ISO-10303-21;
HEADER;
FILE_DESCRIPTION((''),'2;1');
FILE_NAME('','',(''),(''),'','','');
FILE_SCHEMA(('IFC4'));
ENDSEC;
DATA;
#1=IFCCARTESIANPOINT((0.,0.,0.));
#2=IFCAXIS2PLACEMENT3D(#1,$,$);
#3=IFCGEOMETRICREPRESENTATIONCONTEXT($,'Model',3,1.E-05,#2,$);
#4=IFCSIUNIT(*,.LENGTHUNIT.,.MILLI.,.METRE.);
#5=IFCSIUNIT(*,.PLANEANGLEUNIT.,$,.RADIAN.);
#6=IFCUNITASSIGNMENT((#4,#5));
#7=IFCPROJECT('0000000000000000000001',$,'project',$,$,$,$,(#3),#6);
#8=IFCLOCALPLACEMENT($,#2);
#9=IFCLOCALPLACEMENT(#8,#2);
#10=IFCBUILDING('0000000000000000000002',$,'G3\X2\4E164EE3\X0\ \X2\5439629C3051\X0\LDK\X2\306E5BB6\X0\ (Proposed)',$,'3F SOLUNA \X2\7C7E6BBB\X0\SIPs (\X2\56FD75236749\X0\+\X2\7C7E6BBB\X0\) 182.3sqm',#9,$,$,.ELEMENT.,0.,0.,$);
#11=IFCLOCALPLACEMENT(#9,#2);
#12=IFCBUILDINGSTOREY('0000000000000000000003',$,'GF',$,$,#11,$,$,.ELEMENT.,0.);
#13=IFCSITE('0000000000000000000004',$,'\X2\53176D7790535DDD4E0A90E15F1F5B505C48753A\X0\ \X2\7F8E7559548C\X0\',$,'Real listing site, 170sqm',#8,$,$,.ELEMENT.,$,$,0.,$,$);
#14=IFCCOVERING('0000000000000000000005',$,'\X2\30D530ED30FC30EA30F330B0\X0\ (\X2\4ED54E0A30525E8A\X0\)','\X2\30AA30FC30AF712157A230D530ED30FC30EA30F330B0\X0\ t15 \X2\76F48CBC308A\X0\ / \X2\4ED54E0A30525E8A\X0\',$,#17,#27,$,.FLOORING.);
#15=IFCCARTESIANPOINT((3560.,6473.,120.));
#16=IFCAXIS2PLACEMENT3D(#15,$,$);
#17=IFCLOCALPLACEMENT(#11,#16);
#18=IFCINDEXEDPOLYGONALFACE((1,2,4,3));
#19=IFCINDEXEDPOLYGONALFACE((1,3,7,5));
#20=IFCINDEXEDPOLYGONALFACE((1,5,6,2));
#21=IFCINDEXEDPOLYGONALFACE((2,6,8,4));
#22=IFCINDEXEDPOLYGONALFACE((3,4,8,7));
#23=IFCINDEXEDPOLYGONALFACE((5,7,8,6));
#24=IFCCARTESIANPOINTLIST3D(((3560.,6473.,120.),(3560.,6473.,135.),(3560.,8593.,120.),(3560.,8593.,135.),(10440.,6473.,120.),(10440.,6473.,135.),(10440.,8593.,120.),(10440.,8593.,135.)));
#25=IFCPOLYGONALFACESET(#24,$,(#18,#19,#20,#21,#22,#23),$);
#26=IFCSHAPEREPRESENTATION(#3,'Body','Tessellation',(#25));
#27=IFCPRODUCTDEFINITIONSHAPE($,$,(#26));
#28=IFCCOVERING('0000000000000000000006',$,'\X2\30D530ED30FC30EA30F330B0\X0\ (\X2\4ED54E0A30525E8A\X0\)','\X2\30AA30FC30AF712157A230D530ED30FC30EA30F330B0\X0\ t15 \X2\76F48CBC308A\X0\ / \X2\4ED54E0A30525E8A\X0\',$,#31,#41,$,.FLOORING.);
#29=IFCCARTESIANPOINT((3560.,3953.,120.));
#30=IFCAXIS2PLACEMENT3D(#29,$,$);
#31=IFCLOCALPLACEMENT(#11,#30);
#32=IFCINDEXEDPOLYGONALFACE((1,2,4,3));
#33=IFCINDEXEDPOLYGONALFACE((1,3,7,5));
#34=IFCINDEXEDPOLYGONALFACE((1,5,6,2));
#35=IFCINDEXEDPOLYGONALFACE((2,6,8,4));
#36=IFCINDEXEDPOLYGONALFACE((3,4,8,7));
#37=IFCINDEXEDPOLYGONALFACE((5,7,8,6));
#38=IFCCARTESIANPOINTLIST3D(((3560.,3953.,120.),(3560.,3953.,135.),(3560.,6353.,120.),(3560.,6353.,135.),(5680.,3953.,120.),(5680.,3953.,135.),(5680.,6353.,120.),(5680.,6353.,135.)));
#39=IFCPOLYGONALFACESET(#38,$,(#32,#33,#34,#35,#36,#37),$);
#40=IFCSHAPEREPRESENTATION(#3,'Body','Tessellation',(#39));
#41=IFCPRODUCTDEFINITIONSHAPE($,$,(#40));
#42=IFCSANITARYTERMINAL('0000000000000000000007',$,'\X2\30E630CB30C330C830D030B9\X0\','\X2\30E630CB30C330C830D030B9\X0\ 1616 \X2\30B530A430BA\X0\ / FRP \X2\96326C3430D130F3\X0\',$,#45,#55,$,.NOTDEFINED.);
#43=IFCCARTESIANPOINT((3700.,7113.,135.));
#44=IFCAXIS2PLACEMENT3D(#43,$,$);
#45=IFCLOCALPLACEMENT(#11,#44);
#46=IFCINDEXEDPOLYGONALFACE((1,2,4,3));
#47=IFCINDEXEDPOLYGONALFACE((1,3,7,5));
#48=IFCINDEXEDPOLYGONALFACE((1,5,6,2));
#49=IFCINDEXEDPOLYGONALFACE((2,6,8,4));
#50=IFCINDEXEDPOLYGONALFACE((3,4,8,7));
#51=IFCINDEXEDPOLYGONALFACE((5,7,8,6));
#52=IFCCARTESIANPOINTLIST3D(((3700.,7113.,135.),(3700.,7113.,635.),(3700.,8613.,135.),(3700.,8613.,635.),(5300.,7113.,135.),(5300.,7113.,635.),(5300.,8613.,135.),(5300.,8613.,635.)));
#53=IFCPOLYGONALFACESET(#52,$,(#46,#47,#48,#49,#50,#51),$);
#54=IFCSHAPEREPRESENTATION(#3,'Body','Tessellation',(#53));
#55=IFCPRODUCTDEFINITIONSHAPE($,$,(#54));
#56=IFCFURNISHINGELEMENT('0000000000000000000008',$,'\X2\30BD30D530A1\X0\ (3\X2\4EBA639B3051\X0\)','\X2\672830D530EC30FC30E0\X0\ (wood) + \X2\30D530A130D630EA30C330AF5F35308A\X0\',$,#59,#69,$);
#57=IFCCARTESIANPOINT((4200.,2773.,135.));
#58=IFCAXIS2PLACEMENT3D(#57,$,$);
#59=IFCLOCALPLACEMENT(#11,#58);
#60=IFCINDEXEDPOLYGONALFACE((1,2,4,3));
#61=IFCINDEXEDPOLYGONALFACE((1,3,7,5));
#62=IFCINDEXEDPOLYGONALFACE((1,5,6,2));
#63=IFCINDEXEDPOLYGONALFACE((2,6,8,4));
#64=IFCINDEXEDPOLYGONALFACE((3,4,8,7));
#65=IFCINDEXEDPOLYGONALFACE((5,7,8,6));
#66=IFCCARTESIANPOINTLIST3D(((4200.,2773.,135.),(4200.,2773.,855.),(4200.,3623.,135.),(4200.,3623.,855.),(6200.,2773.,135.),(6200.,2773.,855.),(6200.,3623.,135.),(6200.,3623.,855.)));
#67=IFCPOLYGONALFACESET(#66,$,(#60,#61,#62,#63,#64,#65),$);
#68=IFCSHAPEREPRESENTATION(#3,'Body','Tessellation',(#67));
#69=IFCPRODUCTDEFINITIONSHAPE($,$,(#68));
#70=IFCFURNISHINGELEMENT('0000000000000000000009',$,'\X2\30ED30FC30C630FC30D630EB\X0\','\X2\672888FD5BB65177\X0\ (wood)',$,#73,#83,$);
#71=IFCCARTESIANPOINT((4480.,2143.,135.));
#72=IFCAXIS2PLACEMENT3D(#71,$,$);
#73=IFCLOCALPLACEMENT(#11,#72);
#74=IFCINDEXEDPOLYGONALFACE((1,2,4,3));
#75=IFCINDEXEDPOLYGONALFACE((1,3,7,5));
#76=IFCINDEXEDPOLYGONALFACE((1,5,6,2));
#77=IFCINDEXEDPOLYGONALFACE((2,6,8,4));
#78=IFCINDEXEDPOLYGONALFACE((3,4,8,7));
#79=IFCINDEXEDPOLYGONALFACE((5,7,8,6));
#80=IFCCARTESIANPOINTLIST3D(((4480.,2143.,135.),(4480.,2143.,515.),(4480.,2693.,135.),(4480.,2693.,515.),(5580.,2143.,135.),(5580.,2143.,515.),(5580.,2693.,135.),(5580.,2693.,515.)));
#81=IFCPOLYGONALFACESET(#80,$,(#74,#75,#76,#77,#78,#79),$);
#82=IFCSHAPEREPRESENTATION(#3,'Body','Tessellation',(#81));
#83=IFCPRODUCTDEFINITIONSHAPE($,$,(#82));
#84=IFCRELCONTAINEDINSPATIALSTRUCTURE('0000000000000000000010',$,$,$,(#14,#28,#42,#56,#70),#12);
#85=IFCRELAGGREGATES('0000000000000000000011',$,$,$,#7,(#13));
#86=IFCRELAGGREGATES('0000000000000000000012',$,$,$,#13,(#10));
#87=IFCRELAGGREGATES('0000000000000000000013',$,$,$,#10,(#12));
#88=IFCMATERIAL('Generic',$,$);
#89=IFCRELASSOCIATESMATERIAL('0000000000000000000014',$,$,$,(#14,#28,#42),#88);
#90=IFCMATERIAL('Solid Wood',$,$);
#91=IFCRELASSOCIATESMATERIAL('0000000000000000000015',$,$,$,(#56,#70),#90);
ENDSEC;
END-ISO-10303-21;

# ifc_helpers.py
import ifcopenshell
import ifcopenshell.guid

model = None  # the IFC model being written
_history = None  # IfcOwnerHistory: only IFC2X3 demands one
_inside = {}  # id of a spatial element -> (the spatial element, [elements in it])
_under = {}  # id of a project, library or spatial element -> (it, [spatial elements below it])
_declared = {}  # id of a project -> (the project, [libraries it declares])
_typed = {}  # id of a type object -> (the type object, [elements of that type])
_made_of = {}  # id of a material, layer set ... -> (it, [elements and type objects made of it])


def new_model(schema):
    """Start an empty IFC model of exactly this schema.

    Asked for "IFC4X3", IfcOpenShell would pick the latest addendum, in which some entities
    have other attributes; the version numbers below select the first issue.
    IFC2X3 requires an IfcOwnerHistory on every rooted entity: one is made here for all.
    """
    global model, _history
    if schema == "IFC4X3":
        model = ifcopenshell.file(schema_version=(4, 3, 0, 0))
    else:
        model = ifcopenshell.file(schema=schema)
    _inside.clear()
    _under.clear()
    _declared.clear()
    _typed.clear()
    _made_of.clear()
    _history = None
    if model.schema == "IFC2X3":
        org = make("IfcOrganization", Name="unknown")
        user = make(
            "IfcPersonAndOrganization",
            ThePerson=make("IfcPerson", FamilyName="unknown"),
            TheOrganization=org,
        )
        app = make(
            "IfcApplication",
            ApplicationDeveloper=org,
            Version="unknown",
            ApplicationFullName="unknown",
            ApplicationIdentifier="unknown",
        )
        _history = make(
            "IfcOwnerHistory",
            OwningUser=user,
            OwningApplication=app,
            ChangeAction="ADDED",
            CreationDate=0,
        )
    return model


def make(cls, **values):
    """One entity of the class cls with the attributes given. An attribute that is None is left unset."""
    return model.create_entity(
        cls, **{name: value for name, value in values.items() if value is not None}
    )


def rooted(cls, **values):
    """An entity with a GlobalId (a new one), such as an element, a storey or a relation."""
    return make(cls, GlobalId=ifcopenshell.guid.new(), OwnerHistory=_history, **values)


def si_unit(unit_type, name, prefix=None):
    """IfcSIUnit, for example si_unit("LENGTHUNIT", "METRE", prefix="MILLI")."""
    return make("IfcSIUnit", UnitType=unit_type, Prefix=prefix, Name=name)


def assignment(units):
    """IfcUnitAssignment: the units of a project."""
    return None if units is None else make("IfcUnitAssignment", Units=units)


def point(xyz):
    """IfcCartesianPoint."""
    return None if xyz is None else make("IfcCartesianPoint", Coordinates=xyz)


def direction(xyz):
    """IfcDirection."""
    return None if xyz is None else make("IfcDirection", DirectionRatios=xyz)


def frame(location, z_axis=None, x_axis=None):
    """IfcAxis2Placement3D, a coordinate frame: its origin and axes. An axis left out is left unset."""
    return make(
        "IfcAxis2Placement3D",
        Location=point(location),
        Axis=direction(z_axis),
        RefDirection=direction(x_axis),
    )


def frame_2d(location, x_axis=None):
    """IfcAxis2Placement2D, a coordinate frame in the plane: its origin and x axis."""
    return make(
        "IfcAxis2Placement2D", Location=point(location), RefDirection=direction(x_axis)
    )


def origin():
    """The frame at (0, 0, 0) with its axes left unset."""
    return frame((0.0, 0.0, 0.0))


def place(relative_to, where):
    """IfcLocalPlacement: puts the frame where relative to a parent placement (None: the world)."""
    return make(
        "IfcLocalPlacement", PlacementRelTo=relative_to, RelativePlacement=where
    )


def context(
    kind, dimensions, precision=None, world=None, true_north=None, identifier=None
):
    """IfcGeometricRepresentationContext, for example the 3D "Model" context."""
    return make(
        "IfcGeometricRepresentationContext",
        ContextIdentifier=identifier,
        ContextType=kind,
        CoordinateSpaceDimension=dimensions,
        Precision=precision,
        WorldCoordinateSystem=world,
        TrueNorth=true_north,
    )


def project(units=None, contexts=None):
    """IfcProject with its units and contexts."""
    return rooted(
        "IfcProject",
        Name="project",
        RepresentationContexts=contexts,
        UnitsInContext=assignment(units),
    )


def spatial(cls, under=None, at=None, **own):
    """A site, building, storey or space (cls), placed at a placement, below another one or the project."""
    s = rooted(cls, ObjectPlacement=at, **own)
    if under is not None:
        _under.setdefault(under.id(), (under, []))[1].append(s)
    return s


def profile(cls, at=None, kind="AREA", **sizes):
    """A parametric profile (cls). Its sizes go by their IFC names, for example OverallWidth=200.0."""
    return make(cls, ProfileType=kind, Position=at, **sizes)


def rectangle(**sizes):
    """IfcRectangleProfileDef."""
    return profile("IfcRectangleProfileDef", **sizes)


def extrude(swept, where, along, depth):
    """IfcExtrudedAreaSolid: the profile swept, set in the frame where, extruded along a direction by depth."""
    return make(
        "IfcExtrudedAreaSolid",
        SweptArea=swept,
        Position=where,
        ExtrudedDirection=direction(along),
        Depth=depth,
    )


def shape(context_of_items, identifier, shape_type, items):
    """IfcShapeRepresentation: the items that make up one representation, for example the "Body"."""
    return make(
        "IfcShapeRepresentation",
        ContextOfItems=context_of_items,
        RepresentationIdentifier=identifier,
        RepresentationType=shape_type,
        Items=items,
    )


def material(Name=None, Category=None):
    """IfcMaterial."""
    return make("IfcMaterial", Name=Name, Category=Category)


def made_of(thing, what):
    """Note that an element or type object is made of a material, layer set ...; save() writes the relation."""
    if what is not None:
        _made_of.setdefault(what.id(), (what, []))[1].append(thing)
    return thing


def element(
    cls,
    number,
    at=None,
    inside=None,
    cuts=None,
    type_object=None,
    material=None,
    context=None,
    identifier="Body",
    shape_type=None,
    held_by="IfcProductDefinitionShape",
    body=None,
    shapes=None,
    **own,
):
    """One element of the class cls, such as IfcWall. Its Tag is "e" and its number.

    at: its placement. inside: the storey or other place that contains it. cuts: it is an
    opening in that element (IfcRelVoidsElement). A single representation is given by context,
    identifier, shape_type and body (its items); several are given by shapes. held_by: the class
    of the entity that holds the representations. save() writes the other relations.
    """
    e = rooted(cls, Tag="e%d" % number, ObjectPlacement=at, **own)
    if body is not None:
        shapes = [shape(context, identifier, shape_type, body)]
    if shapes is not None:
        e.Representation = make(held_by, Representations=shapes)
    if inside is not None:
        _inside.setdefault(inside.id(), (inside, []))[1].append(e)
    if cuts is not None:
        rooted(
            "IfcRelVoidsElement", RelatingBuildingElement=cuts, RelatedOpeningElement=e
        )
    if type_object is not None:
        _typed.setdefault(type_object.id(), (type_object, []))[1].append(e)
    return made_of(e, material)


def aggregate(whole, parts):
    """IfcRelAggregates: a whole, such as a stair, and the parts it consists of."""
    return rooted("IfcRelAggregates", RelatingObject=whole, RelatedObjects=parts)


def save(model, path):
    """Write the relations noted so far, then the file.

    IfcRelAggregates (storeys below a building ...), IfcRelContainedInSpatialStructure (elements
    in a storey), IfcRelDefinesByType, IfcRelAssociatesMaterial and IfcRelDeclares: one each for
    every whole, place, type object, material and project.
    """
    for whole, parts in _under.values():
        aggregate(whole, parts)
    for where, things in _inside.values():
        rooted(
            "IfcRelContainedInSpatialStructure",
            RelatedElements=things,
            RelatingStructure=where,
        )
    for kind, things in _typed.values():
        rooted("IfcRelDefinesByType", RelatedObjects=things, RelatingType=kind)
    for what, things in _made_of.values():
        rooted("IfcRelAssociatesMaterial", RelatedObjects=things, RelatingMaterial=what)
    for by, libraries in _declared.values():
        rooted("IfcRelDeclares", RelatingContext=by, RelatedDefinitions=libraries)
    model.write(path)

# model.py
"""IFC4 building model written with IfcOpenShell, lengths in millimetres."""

from ifc_helpers import new_model, si_unit, frame, frame_2d, origin, place, context, project, spatial, rectangle, extrude, material, element, save


model = new_model("IFC4")

# Units and contexts
model_context = context("Model", 3, precision=1e-05, world=origin())
ifc_project = project(units=[si_unit("LENGTHUNIT", "METRE", prefix="MILLI"), si_unit("PLANEANGLEUNIT", "RADIAN")], contexts=[model_context])

# Site, building, storey
site_placement = place(None, origin())
site = spatial("IfcSite", under=ifc_project, at=site_placement, Name="北海道川上郡弟子屈町 美留和", ObjectType="Real listing site, 170sqm", CompositionType="ELEMENT", RefElevation=0.0)
building_placement = place(site_placement, origin())
building = spatial("IfcBuilding", under=site, at=building_placement, Name="G3世代 吹抜けLDKの家 (Proposed)", ObjectType="3F SOLUNA 籾殻SIPs (国産杉+籾殻) 182.3sqm", CompositionType="ELEMENT", ElevationOfRefHeight=0.0, ElevationOfTerrain=0.0)
storey_placement = place(building_placement, origin())
storey = spatial("IfcBuildingStorey", under=building, at=storey_placement, Name="GF", CompositionType="ELEMENT", Elevation=0.0)

# Shared definitions
ifc_material_1 = material(Name="Solid Wood")

# Coverings
ifc_material_2 = material(Name="Generic")
covering_1_placement = place(storey_placement, frame((3560.0, 6473.0, 120.0)))
element("IfcCovering", 1, at=covering_1_placement, inside=storey, material=ifc_material_2, Name="フローリング (仕上げ床)", Description="オーク無垢フローリング t15 直貼り / 仕上げ床", PredefinedType="FLOORING", context=model_context, shape_type="SweptSolid", body=[
    extrude(rectangle(XDim=6880.0, YDim=2120.0, at=frame_2d((3440.0, 1060.0))), frame((3560.0, 6473.0, 120.0)), (0.0, 0.0, 1.0), 15.0),
])
covering_2_placement = place(storey_placement, frame((3560.0, 3953.0, 120.0)))
element("IfcCovering", 2, at=covering_2_placement, inside=storey, material=ifc_material_2, Name="フローリング (仕上げ床)", Description="オーク無垢フローリング t15 直貼り / 仕上げ床", PredefinedType="FLOORING", context=model_context, shape_type="SweptSolid", body=[
    extrude(rectangle(XDim=2120.0, YDim=2400.0, at=frame_2d((1060.0, 1200.0))), frame((3560.0, 3953.0, 120.0)), (0.0, 0.0, 1.0), 15.0),
])

# Sanitary terminal
sanitary_terminal_placement = place(storey_placement, frame((3700.0, 7113.0, 135.0)))
element("IfcSanitaryTerminal", 3, at=sanitary_terminal_placement, inside=storey, material=ifc_material_2, Name="ユニットバス", Description="ユニットバス 1616 サイズ / FRP 防水パン", PredefinedType="NOTDEFINED", context=model_context, shape_type="SweptSolid", body=[
    extrude(rectangle(XDim=1600.0, YDim=1500.0, at=frame_2d((800.0, 750.0))), frame((3700.0, 7113.0, 135.0)), (0.0, 0.0, 1.0), 500.0),
])

# Furnishing elements
furnishing_1_placement = place(storey_placement, frame((4200.0, 2773.0, 135.0)))
element("IfcFurnishingElement", 4, at=furnishing_1_placement, inside=storey, material=ifc_material_1, Name="ソファ (3人掛け)", Description="木フレーム (wood) + ファブリック張り", context=model_context, shape_type="SweptSolid", body=[
    extrude(rectangle(XDim=2000.0, YDim=850.0, at=frame_2d((1000.0, 425.0))), frame((4200.0, 2773.0, 135.0)), (0.0, 0.0, 1.0), 720.0),
])
furnishing_2_placement = place(storey_placement, frame((4480.0, 2143.0, 135.0)))
element("IfcFurnishingElement", 5, at=furnishing_2_placement, inside=storey, material=ifc_material_1, Name="ローテーブル", Description="木製家具 (wood)", context=model_context, shape_type="SweptSolid", body=[
    extrude(rectangle(XDim=1100.0, YDim=550.0, at=frame_2d((550.0, 275.0))), frame((4480.0, 2143.0, 135.0)), (0.0, 0.0, 1.0), 380.0),
])

save(model, "model.ifc")
